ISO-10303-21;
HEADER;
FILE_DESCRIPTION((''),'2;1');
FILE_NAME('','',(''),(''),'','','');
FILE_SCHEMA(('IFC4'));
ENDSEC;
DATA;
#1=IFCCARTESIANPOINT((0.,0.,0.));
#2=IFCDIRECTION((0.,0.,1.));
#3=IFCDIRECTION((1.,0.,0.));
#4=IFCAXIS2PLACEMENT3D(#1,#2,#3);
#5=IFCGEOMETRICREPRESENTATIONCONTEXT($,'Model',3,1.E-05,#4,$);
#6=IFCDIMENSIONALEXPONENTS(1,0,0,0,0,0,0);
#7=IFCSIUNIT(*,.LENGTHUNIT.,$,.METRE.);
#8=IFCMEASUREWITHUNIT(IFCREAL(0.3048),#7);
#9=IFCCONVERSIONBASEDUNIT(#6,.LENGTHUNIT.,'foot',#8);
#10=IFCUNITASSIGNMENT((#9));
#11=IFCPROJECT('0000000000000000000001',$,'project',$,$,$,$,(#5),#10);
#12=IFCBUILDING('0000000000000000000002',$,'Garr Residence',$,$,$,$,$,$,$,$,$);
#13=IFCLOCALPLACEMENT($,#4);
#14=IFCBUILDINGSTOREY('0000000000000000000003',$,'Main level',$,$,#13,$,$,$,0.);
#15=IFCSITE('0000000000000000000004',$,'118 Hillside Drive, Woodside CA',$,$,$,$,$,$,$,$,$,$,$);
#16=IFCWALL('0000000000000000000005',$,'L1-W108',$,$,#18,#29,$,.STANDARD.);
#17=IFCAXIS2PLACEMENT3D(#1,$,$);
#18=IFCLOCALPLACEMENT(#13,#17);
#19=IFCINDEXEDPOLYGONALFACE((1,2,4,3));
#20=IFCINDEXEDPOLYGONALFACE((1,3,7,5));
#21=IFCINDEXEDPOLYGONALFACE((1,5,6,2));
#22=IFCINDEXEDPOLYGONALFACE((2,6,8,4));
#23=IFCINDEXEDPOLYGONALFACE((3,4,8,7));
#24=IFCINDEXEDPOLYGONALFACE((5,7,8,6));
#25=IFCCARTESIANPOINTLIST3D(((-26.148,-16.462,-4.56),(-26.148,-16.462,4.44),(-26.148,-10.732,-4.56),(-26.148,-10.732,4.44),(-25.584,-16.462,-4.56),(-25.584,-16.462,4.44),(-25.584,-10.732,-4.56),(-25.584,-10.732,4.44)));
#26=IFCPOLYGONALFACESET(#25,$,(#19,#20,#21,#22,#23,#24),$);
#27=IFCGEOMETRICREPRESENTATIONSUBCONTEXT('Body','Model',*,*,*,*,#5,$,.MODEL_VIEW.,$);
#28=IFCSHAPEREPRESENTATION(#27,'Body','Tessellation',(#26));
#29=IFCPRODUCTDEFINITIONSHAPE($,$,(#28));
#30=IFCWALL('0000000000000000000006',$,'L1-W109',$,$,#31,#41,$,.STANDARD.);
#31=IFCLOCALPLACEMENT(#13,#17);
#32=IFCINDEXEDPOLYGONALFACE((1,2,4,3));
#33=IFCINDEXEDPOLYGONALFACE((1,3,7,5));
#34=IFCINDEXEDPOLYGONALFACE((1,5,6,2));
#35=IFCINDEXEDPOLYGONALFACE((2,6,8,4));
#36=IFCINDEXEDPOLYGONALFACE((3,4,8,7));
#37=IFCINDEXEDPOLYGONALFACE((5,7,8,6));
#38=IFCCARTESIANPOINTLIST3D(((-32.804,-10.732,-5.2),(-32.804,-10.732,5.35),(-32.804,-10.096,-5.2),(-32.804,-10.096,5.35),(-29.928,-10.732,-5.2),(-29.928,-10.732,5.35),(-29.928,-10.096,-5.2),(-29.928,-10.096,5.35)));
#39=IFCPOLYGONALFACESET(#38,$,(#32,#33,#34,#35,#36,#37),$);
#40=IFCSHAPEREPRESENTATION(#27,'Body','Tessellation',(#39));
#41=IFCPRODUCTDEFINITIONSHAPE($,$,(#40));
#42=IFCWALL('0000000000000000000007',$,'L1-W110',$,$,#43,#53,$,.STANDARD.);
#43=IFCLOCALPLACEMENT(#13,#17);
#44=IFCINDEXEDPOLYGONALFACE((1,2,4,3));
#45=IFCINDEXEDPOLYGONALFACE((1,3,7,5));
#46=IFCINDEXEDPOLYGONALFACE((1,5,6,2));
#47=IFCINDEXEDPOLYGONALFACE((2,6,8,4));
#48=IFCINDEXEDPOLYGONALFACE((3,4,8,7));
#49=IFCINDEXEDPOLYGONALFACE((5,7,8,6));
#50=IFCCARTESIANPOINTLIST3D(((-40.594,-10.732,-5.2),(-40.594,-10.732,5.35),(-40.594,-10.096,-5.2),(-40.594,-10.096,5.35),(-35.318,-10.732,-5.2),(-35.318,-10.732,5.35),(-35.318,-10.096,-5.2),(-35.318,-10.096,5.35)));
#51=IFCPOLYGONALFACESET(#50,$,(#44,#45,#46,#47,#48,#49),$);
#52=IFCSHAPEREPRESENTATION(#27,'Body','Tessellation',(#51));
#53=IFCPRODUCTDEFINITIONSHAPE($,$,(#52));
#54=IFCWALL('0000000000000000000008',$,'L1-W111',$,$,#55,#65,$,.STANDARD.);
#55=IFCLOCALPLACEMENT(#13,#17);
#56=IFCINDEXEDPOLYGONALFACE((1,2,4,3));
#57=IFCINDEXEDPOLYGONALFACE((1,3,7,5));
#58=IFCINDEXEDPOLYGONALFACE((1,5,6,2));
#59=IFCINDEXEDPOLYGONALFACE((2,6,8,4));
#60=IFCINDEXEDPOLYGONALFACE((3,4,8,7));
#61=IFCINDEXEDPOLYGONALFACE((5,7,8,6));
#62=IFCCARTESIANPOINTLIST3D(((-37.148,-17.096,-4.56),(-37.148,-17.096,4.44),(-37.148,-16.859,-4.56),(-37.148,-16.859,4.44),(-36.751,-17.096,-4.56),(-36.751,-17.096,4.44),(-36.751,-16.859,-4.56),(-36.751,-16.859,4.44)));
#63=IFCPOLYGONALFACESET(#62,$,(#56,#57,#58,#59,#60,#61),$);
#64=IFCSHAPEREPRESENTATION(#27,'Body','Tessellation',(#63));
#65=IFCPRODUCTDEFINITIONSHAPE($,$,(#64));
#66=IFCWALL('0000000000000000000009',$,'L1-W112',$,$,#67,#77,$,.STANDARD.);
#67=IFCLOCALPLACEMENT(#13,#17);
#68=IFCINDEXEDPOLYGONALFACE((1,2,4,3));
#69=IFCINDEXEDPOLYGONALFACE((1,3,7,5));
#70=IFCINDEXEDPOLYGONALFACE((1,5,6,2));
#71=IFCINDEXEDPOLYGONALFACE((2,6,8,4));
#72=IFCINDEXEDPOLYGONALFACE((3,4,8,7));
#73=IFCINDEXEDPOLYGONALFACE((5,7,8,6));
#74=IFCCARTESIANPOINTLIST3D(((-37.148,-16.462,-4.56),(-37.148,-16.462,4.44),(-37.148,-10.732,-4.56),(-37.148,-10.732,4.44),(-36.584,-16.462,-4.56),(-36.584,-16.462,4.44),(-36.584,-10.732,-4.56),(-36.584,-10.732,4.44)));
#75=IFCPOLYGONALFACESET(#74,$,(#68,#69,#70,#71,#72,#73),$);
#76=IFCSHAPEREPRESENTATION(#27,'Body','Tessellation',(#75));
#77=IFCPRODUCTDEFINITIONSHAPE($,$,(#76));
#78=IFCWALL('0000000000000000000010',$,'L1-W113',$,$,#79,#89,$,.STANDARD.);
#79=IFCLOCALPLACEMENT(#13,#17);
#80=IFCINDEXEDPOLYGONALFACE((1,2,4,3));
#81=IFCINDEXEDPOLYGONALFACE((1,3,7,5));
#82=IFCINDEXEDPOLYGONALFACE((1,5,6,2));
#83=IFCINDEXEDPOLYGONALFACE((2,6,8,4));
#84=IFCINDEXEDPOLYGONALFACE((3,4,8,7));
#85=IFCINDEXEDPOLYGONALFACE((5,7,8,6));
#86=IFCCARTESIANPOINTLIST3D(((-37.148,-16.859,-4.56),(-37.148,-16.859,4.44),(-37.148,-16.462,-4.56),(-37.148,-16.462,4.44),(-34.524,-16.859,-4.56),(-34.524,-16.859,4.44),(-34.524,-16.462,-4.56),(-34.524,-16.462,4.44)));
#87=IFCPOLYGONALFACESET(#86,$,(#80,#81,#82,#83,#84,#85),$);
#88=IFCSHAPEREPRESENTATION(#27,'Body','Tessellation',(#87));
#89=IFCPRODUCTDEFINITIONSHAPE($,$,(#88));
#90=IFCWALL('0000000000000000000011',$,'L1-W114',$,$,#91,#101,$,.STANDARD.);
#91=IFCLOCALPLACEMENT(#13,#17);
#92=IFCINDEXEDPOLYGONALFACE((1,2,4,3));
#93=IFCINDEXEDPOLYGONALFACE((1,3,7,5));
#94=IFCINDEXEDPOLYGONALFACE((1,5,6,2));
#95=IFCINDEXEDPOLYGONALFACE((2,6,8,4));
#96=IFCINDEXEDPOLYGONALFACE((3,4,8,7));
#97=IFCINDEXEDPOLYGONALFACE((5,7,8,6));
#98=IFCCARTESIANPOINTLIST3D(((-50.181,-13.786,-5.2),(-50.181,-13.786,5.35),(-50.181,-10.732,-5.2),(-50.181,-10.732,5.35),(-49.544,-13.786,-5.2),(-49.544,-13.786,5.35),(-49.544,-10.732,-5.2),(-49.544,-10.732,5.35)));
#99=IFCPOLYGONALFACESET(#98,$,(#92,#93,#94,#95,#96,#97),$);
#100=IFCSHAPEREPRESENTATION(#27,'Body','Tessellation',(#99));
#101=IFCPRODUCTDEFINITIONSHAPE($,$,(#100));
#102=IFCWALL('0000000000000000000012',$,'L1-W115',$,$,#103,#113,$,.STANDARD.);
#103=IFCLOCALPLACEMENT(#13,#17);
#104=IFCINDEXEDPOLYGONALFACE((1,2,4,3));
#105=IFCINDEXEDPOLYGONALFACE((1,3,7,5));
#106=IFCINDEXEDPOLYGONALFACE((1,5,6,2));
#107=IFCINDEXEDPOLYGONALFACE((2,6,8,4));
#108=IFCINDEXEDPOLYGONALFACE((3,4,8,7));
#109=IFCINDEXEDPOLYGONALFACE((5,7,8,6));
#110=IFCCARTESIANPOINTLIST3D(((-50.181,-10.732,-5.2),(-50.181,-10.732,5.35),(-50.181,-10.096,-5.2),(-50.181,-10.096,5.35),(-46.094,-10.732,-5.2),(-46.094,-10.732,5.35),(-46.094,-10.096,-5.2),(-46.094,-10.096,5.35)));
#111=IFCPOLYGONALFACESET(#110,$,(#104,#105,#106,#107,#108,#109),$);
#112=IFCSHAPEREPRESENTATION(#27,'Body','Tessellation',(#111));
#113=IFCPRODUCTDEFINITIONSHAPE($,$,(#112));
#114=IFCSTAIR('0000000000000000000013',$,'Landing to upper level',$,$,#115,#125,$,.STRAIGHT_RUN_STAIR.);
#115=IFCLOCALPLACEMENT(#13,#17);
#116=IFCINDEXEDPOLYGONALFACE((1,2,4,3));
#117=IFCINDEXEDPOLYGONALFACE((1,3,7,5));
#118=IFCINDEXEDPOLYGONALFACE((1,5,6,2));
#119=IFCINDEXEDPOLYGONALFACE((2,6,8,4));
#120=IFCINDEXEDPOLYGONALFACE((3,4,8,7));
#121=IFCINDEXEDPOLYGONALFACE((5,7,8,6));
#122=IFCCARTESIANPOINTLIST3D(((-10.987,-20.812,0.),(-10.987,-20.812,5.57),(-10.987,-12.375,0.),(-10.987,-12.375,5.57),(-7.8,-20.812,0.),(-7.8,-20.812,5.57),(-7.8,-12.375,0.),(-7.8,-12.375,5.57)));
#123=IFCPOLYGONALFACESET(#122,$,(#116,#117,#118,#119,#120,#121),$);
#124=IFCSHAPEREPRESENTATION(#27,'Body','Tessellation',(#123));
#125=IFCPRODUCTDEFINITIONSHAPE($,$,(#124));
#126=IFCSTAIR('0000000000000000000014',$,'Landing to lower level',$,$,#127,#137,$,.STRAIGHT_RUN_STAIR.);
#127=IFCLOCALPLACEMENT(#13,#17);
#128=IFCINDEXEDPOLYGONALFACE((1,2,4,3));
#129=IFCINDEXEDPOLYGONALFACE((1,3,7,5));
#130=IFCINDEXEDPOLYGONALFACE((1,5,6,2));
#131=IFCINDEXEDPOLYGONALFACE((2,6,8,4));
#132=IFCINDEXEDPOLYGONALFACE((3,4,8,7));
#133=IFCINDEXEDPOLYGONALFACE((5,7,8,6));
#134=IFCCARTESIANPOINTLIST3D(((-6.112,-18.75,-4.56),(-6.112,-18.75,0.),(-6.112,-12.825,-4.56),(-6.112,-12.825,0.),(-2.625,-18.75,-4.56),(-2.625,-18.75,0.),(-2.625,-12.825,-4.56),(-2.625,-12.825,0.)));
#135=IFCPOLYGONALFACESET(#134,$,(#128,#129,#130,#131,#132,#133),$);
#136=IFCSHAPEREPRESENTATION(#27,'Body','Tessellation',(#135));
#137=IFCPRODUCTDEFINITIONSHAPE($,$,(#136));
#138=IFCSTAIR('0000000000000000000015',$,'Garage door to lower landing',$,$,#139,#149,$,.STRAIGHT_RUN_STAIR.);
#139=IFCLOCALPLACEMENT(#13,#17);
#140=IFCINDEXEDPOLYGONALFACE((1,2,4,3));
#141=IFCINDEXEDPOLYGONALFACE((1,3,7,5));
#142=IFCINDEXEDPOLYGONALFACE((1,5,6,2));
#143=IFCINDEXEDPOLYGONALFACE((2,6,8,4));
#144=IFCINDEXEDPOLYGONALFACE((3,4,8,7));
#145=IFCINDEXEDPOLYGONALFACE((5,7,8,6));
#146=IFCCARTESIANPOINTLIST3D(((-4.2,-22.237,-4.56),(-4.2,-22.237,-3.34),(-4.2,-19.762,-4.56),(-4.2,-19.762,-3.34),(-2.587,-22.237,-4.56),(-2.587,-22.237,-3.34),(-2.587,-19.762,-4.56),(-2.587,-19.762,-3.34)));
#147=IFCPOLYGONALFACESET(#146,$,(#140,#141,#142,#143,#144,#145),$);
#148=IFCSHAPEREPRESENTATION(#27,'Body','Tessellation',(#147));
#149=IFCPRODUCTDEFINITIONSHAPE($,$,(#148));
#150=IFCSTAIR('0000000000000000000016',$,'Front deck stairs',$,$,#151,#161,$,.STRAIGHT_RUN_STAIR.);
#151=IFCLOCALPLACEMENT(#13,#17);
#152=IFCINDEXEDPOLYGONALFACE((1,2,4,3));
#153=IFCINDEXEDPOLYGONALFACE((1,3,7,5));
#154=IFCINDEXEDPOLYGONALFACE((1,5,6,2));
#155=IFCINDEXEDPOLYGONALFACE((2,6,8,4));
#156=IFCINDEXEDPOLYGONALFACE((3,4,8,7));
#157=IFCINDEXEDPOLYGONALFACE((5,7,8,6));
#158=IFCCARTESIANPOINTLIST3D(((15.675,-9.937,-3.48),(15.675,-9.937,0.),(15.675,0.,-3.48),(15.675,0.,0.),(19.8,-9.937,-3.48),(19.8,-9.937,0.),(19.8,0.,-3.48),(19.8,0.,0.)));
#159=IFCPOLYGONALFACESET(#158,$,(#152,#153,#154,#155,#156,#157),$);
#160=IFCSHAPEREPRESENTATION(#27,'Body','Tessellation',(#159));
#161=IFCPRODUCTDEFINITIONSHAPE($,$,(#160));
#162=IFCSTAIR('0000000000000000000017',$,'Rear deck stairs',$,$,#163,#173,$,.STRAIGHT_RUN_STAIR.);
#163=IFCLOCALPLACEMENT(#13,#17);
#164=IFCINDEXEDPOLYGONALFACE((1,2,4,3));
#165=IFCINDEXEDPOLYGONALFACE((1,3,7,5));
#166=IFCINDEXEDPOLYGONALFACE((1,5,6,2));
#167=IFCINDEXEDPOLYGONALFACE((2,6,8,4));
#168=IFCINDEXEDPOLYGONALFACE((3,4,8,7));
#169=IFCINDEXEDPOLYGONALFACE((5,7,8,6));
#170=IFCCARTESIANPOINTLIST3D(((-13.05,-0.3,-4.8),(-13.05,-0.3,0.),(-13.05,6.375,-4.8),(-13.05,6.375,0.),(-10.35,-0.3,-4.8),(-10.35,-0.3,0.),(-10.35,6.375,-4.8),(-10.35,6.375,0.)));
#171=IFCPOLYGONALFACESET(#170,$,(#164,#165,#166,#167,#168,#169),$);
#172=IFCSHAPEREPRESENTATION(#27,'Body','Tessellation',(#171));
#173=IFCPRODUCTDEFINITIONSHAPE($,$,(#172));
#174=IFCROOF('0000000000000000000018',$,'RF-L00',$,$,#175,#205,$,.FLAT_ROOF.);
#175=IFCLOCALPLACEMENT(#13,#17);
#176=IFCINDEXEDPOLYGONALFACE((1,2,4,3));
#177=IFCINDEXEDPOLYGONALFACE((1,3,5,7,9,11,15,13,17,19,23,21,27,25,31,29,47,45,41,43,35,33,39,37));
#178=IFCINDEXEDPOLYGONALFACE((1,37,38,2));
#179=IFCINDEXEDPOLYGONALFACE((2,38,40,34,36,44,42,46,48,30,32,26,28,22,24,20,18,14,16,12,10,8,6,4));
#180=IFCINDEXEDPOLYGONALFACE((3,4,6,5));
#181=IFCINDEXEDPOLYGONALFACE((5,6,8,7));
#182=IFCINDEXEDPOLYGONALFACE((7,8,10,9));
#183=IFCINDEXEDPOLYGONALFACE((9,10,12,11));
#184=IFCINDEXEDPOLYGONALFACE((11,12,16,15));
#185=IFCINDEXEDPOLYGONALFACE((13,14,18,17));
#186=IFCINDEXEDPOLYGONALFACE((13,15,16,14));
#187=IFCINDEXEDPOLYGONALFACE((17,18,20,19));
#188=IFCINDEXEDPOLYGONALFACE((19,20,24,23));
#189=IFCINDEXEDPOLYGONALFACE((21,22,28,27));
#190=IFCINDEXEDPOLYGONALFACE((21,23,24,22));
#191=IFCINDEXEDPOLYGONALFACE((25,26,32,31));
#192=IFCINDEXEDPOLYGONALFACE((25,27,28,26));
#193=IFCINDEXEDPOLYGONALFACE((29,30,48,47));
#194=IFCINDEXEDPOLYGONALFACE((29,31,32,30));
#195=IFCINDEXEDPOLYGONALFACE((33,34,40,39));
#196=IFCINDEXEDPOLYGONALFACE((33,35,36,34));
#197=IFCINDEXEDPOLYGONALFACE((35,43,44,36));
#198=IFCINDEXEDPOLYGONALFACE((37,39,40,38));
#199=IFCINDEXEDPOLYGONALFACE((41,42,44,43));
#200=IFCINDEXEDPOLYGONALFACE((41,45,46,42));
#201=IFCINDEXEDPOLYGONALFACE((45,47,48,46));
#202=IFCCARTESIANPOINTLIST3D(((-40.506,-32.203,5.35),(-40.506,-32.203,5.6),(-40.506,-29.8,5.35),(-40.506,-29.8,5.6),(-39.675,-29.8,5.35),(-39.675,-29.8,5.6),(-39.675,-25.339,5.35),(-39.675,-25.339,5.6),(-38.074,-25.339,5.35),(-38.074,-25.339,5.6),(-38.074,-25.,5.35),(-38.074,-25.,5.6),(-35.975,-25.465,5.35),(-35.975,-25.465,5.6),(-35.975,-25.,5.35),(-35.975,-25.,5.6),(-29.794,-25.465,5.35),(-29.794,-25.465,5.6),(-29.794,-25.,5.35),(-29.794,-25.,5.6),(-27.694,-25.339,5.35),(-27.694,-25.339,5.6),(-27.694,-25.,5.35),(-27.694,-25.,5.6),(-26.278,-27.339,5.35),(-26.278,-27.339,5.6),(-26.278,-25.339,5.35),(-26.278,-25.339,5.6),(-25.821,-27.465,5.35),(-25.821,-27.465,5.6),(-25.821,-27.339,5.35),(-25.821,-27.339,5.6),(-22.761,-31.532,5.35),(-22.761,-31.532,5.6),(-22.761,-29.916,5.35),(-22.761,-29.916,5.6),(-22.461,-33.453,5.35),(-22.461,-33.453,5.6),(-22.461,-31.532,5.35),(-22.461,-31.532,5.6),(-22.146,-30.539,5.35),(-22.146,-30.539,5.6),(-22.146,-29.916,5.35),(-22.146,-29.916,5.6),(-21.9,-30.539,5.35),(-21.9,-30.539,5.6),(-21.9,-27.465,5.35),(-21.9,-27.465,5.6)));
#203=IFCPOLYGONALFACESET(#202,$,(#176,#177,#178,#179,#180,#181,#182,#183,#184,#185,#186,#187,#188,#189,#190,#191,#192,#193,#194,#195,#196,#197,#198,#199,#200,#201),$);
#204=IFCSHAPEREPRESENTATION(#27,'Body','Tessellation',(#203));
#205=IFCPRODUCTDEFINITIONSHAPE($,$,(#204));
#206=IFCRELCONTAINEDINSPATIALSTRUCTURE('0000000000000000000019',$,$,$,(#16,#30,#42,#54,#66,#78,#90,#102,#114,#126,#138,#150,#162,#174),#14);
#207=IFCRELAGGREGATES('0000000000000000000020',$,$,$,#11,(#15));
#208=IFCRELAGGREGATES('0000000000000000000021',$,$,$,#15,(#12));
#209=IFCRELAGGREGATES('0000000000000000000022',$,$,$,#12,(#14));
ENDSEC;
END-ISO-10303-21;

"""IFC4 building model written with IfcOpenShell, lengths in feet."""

from ifc_helpers import new_model, entity, si_unit, converted_unit, frame, origin, origin_with_axes, place, context, subcontext, project, spatial, polyline, outline, extrude, element, save


model = new_model("IFC4")

# Units and contexts
model_context = context("Model", 3, precision=1e-05, world=origin_with_axes())
body_context = subcontext(model_context, "Body", "Model", "MODEL_VIEW")
ifc_project = project(units=[converted_unit("LENGTHUNIT", "foot", entity("IfcReal", 0.3048), si_unit("LENGTHUNIT", "METRE"), dimensions=[1, 0, 0, 0, 0, 0, 0])], contexts=[model_context])

# Site, building, storey
site = spatial("IfcSite", under=ifc_project, Name="118 Hillside Drive, Woodside CA")
building = spatial("IfcBuilding", under=site, Name="Garr Residence")
storey_placement = place(None, origin_with_axes())
storey = spatial("IfcBuildingStorey", under=building, at=storey_placement, Name="Main level", Elevation=0.0)

# Walls
wall_1_placement = place(storey_placement, frame((0.0, 0.0, -4.56), z_axis=(0.0, 0.0, 1.0), x_axis=(1.0, 0.0, 0.0)))
element("IfcWall", 1, at=wall_1_placement, inside=storey, Name="L1-W108", PredefinedType="STANDARD", context=body_context, shape_type="SweptSolid", body=[
    extrude(outline(polyline([(-25.584, -16.462), (-25.584, -10.732), (-26.148, -10.732), (-26.148, -16.462), (-25.584, -16.462)])), origin(), (0.0, 0.0, 1.0), 9.0),
])
wall_2_placement = place(storey_placement, frame((0.0, 0.0, -5.2), z_axis=(0.0, 0.0, 1.0), x_axis=(1.0, 0.0, 0.0)))
element("IfcWall", 2, at=wall_2_placement, inside=storey, Name="L1-W109", PredefinedType="STANDARD", context=body_context, shape_type="SweptSolid", body=[
    extrude(outline(polyline([(-29.928, -10.732), (-29.928, -10.096), (-32.804, -10.096), (-32.804, -10.732), (-29.928, -10.732)])), origin(), (0.0, 0.0, 1.0), 10.55),
])
wall_3_placement = place(storey_placement, frame((0.0, 0.0, -5.2), z_axis=(0.0, 0.0, 1.0), x_axis=(1.0, 0.0, 0.0)))
element("IfcWall", 3, at=wall_3_placement, inside=storey, Name="L1-W110", PredefinedType="STANDARD", context=body_context, shape_type="SweptSolid", body=[
    extrude(outline(polyline([(-35.318, -10.732), (-35.318, -10.096), (-40.594, -10.096), (-40.594, -10.732), (-35.318, -10.732)])), origin(), (0.0, 0.0, 1.0), 10.55),
])
wall_4_placement = place(storey_placement, frame((0.0, 0.0, -4.56), z_axis=(0.0, 0.0, 1.0), x_axis=(1.0, 0.0, 0.0)))
element("IfcWall", 4, at=wall_4_placement, inside=storey, Name="L1-W111", PredefinedType="STANDARD", context=body_context, shape_type="SweptSolid", body=[
    extrude(outline(polyline([(-36.751, -17.096), (-36.751, -16.859), (-37.148, -16.859), (-37.148, -17.096), (-36.751, -17.096)])), origin(), (0.0, 0.0, 1.0), 9.0),
])
wall_5_placement = place(storey_placement, frame((0.0, 0.0, -4.56), z_axis=(0.0, 0.0, 1.0), x_axis=(1.0, 0.0, 0.0)))
element("IfcWall", 5, at=wall_5_placement, inside=storey, Name="L1-W112", PredefinedType="STANDARD", context=body_context, shape_type="SweptSolid", body=[
    extrude(outline(polyline([(-36.584, -16.462), (-36.584, -10.732), (-37.148, -10.732), (-37.148, -16.462), (-36.584, -16.462)])), origin(), (0.0, 0.0, 1.0), 9.0),
])
wall_6_placement = place(storey_placement, frame((0.0, 0.0, -4.56), z_axis=(0.0, 0.0, 1.0), x_axis=(1.0, 0.0, 0.0)))
element("IfcWall", 6, at=wall_6_placement, inside=storey, Name="L1-W113", PredefinedType="STANDARD", context=body_context, shape_type="SweptSolid", body=[
    extrude(outline(polyline([(-34.524, -16.859), (-34.524, -16.462), (-37.148, -16.462), (-37.148, -16.859), (-34.524, -16.859)])), origin(), (0.0, 0.0, 1.0), 9.0),
])
wall_7_placement = place(storey_placement, frame((0.0, 0.0, -5.2), z_axis=(0.0, 0.0, 1.0), x_axis=(1.0, 0.0, 0.0)))
element("IfcWall", 7, at=wall_7_placement, inside=storey, Name="L1-W114", PredefinedType="STANDARD", context=body_context, shape_type="SweptSolid", body=[
    extrude(outline(polyline([(-49.544, -13.786), (-49.544, -10.732), (-50.181, -10.732), (-50.181, -13.786), (-49.544, -13.786)])), origin(), (0.0, 0.0, 1.0), 10.55),
])
wall_8_placement = place(storey_placement, frame((0.0, 0.0, -5.2), z_axis=(0.0, 0.0, 1.0), x_axis=(1.0, 0.0, 0.0)))
element("IfcWall", 8, at=wall_8_placement, inside=storey, Name="L1-W115", PredefinedType="STANDARD", context=body_context, shape_type="SweptSolid", body=[
    extrude(outline(polyline([(-46.094, -10.732), (-46.094, -10.096), (-50.181, -10.096), (-50.181, -10.732), (-46.094, -10.732)])), origin(), (0.0, 0.0, 1.0), 10.55),
])

# Stairs
stair_1_placement = place(storey_placement, origin_with_axes())
element("IfcStair", 9, at=stair_1_placement, inside=storey, Name="Landing to upper level", PredefinedType="STRAIGHT_RUN_STAIR", context=body_context, shape_type="SweptSolid", body=[
    extrude(outline(polyline([(-10.987, -20.812), (-7.8, -20.812), (-7.8, -12.375), (-10.987, -12.375), (-10.987, -20.812)])), origin(), (0.0, 0.0, 1.0), 5.57),
])
stair_2_placement = place(storey_placement, frame((0.0, 0.0, -4.56), z_axis=(0.0, 0.0, 1.0), x_axis=(1.0, 0.0, 0.0)))
element("IfcStair", 10, at=stair_2_placement, inside=storey, Name="Landing to lower level", PredefinedType="STRAIGHT_RUN_STAIR", context=body_context, shape_type="SweptSolid", body=[
    extrude(outline(polyline([(-6.112, -18.75), (-2.625, -18.75), (-2.625, -12.825), (-6.112, -12.825), (-6.112, -18.75)])), origin(), (0.0, 0.0, 1.0), 4.56),
])
stair_3_placement = place(storey_placement, frame((0.0, 0.0, -4.56), z_axis=(0.0, 0.0, 1.0), x_axis=(1.0, 0.0, 0.0)))
element("IfcStair", 11, at=stair_3_placement, inside=storey, Name="Garage door to lower landing", PredefinedType="STRAIGHT_RUN_STAIR", context=body_context, shape_type="SweptSolid", body=[
    extrude(outline(polyline([(-4.2, -22.237), (-2.587, -22.237), (-2.587, -19.762), (-4.2, -19.762), (-4.2, -22.237)])), origin(), (0.0, 0.0, 1.0), 1.22),
])
stair_4_placement = place(storey_placement, frame((0.0, 0.0, -3.48), z_axis=(0.0, 0.0, 1.0), x_axis=(1.0, 0.0, 0.0)))
element("IfcStair", 12, at=stair_4_placement, inside=storey, Name="Front deck stairs", PredefinedType="STRAIGHT_RUN_STAIR", context=body_context, shape_type="SweptSolid", body=[
    extrude(outline(polyline([(15.675, -9.937), (19.8, -9.937), (19.8, 0.0), (15.675, 0.0), (15.675, -9.937)])), origin(), (0.0, 0.0, 1.0), 3.48),
])
stair_5_placement = place(storey_placement, frame((0.0, 0.0, -4.8), z_axis=(0.0, 0.0, 1.0), x_axis=(1.0, 0.0, 0.0)))
element("IfcStair", 13, at=stair_5_placement, inside=storey, Name="Rear deck stairs", PredefinedType="STRAIGHT_RUN_STAIR", context=body_context, shape_type="SweptSolid", body=[
    extrude(outline(polyline([(-13.05, -0.3), (-10.35, -0.3), (-10.35, 6.375), (-13.05, 6.375), (-13.05, -0.3)])), origin(), (0.0, 0.0, 1.0), 4.8),
])

# Roof
roof_1_placement = place(storey_placement, frame((0.0, 0.0, 5.35), z_axis=(0.0, 0.0, 1.0), x_axis=(1.0, 0.0, 0.0)))
element("IfcRoof", 14, at=roof_1_placement, inside=storey, Name="RF-L00", PredefinedType="FLAT_ROOF", context=body_context, shape_type="SweptSolid", body=[
    extrude(outline(polyline([(-38.074, -25.339), (-38.074, -25.0), (-35.975, -25.0), (-35.975, -25.465), (-29.794, -25.465), (-29.794, -25.0), (-27.694, -25.0), (-27.694, -25.339), (-26.278, -25.339), (-26.278, -27.339), (-25.821, -27.339), (-25.821, -27.465), (-21.9, -27.465), (-21.9, -30.539), (-22.146, -30.539), (-22.146, -29.916), (-22.761, -29.916), (-22.761, -31.532), (-22.461, -31.532), (-22.461, -33.453), (-40.506, -32.203), (-40.506, -29.8), (-39.675, -29.8), (-39.675, -25.339), (-38.074, -25.339)])), origin(), (0.0, 0.0, 1.0), 0.25),
])

save(model, "model.ifc")
